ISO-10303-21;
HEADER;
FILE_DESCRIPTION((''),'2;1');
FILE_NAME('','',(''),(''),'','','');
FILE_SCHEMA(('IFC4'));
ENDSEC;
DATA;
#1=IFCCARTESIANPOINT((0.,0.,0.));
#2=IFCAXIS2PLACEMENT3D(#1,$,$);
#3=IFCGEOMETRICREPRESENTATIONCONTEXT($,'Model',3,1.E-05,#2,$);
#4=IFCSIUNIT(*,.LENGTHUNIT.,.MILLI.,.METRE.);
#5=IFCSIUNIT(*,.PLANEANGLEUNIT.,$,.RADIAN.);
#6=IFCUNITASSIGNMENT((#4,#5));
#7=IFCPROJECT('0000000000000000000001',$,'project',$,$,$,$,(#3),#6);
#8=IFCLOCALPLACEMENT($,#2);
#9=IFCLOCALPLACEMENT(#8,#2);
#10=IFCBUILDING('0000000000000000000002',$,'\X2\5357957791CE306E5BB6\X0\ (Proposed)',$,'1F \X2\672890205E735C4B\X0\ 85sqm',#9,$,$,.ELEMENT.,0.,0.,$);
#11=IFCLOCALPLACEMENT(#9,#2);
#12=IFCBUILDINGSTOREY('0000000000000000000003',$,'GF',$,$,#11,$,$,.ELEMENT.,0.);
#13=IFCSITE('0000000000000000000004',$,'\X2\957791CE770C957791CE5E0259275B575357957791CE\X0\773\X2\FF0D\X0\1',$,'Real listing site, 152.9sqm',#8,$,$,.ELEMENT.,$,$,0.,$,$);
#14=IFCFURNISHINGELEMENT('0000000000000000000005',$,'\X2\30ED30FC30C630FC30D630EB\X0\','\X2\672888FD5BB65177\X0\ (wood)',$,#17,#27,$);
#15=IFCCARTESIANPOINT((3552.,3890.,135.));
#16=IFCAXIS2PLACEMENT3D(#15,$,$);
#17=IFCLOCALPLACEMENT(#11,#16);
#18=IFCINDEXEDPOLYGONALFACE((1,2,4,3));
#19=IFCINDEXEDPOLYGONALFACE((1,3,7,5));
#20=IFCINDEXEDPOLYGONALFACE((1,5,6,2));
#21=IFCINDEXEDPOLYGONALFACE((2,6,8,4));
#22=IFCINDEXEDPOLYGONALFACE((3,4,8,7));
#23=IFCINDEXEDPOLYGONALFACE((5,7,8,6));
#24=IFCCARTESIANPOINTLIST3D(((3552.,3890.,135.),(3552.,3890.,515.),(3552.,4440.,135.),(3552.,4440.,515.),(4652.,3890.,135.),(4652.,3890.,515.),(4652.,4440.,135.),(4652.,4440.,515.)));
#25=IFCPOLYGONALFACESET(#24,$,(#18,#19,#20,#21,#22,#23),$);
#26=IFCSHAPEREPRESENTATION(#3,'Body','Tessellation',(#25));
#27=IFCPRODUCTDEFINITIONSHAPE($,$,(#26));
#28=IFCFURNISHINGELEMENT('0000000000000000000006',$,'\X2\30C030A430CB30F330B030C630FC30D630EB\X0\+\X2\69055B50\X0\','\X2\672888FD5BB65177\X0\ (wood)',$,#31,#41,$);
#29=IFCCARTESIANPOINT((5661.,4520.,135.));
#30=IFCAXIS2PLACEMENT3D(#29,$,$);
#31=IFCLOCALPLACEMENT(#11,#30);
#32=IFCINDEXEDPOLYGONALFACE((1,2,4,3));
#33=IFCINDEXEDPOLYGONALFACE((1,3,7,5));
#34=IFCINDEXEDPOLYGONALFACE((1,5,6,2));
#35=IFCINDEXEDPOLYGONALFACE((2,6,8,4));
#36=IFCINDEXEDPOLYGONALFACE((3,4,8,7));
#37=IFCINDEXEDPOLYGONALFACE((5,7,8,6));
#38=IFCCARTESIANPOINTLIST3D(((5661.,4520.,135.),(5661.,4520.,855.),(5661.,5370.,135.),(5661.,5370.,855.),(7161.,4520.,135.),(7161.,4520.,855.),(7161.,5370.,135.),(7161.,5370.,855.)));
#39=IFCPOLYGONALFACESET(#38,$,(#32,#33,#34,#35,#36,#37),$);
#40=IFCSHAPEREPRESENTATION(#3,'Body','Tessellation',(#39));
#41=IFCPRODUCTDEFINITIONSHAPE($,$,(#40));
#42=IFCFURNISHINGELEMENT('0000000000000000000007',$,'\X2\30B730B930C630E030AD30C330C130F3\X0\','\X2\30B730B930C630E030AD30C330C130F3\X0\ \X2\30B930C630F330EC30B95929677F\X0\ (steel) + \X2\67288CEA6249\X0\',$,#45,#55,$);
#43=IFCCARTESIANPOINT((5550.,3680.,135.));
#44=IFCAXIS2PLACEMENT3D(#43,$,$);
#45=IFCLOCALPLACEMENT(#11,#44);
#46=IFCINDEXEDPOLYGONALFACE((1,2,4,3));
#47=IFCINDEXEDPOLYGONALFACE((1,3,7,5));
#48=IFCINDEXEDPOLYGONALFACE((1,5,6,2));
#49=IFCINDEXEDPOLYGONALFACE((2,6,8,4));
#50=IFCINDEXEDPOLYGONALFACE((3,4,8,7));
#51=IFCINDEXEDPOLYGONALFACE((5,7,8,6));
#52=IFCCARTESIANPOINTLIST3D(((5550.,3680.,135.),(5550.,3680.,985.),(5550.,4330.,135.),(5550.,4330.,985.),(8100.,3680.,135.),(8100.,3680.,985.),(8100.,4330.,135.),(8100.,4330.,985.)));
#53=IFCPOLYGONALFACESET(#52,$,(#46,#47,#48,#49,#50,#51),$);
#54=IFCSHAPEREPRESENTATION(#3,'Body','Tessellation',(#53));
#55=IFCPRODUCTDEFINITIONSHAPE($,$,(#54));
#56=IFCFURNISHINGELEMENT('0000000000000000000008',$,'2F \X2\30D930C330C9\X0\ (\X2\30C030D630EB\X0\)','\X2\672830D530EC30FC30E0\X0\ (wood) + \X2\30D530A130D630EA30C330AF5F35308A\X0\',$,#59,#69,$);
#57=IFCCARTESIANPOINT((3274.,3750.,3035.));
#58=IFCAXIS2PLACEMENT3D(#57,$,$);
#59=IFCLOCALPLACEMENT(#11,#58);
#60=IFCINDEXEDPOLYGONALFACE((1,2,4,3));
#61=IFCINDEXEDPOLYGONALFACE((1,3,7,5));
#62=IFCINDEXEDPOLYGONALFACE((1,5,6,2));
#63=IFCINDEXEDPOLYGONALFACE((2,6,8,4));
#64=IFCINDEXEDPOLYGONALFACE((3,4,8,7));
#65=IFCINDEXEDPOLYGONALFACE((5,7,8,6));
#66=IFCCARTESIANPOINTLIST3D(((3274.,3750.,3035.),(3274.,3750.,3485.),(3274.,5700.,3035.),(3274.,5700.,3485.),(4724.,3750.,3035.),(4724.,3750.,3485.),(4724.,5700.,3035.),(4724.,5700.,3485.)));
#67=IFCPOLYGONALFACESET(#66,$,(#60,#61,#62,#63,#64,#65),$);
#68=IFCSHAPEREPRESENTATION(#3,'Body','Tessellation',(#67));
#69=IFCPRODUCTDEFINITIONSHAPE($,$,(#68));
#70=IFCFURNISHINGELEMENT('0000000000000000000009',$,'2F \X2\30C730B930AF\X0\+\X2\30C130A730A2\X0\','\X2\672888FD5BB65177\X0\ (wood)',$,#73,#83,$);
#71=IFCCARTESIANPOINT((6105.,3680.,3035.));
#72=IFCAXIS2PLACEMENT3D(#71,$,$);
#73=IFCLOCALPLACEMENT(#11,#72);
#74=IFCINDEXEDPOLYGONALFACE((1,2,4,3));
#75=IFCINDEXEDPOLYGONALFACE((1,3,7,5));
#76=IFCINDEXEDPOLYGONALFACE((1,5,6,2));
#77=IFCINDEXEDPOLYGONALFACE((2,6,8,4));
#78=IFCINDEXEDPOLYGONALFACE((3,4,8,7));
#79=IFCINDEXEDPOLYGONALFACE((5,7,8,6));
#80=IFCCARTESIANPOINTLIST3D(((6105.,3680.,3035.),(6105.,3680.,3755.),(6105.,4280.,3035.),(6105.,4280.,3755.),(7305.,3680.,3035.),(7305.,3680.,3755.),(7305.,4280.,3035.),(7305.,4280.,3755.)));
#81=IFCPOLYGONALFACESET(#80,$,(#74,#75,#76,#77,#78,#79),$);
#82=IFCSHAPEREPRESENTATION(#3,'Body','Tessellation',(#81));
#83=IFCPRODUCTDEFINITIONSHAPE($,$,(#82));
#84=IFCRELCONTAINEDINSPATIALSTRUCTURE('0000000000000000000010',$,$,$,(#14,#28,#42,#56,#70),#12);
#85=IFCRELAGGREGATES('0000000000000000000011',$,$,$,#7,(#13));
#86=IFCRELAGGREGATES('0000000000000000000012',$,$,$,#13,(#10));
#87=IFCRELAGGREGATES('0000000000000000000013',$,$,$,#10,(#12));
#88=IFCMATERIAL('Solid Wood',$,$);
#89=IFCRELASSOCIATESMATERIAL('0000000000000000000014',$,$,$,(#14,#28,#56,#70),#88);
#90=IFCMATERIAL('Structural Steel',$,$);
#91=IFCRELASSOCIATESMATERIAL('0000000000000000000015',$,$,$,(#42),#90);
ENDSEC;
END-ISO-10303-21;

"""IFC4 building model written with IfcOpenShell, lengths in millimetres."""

from ifc_helpers import new_model, si_unit, frame, frame_2d, origin, place, context, project, spatial, rectangle, extrude, material, element, save


model = new_model("IFC4")

# Units and contexts
model_context = context("Model", 3, precision=1e-05, world=origin())
ifc_project = project(units=[si_unit("LENGTHUNIT", "METRE", prefix="MILLI"), si_unit("PLANEANGLEUNIT", "RADIAN")], contexts=[model_context])

# Site, building, storey
site_placement = place(None, origin())
site = spatial("IfcSite", under=ifc_project, at=site_placement, Name="長野県長野市大字南長野773－1", ObjectType="Real listing site, 152.9sqm", CompositionType="ELEMENT", RefElevation=0.0)
building_placement = place(site_placement, origin())
building = spatial("IfcBuilding", under=site, at=building_placement, Name="南長野の家 (Proposed)", ObjectType="1F 木造平屋 85sqm", CompositionType="ELEMENT", ElevationOfRefHeight=0.0, ElevationOfTerrain=0.0)
storey_placement = place(building_placement, origin())
storey = spatial("IfcBuildingStorey", under=building, at=storey_placement, Name="GF", CompositionType="ELEMENT", Elevation=0.0)

# Shared definitions
ifc_material_1 = material(Name="Solid Wood")

# Shared definitions
ifc_material_2 = material(Name="Structural Steel")

# Furnishing elements
furnishing_1_placement = place(storey_placement, frame((3552.0, 3890.0, 135.0)))
element("IfcFurnishingElement", 1, at=furnishing_1_placement, inside=storey, material=ifc_material_1, Name="ローテーブル", Description="木製家具 (wood)", context=model_context, shape_type="SweptSolid", body=[
    extrude(rectangle(XDim=1100.0, YDim=550.0, at=frame_2d((550.0, 275.0))), frame((3552.0, 3890.0, 135.0)), (0.0, 0.0, 1.0), 380.0),
])
furnishing_2_placement = place(storey_placement, frame((5661.0, 4520.0, 135.0)))
element("IfcFurnishingElement", 2, at=furnishing_2_placement, inside=storey, material=ifc_material_1, Name="ダイニングテーブル+椅子", Description="木製家具 (wood)", context=model_context, shape_type="SweptSolid", body=[
    extrude(rectangle(XDim=1500.0, YDim=850.0, at=frame_2d((750.0, 425.0))), frame((5661.0, 4520.0, 135.0)), (0.0, 0.0, 1.0), 720.0),
])
furnishing_3_placement = place(storey_placement, frame((5550.0, 3680.0, 135.0)))
element("IfcFurnishingElement", 3, at=furnishing_3_placement, inside=storey, material=ifc_material_2, Name="システムキッチン", Description="システムキッチン ステンレス天板 (steel) + 木質扉", context=model_context, shape_type="SweptSolid", body=[
    extrude(rectangle(XDim=2550.0, YDim=650.0, at=frame_2d((1275.0, 325.0))), frame((5550.0, 3680.0, 135.0)), (0.0, 0.0, 1.0), 850.0),
])
furnishing_4_placement = place(storey_placement, frame((3274.0, 3750.0, 3035.0)))
element("IfcFurnishingElement", 4, at=furnishing_4_placement, inside=storey, material=ifc_material_1, Name="2F ベッド (ダブル)", Description="木フレーム (wood) + ファブリック張り", context=model_context, shape_type="SweptSolid", body=[
    extrude(rectangle(XDim=1450.0, YDim=1950.0, at=frame_2d((725.0, 975.0))), frame((3274.0, 3750.0, 3035.0)), (0.0, 0.0, 1.0), 450.0),
])
furnishing_5_placement = place(storey_placement, frame((6105.0, 3680.0, 3035.0)))
element("IfcFurnishingElement", 5, at=furnishing_5_placement, inside=storey, material=ifc_material_1, Name="2F デスク+チェア", Description="木製家具 (wood)", context=model_context, shape_type="SweptSolid", body=[
    extrude(rectangle(XDim=1200.0, YDim=600.0, at=frame_2d((600.0, 300.0))), frame((6105.0, 3680.0, 3035.0)), (0.0, 0.0, 1.0), 720.0),
])

save(model, "model.ifc")
